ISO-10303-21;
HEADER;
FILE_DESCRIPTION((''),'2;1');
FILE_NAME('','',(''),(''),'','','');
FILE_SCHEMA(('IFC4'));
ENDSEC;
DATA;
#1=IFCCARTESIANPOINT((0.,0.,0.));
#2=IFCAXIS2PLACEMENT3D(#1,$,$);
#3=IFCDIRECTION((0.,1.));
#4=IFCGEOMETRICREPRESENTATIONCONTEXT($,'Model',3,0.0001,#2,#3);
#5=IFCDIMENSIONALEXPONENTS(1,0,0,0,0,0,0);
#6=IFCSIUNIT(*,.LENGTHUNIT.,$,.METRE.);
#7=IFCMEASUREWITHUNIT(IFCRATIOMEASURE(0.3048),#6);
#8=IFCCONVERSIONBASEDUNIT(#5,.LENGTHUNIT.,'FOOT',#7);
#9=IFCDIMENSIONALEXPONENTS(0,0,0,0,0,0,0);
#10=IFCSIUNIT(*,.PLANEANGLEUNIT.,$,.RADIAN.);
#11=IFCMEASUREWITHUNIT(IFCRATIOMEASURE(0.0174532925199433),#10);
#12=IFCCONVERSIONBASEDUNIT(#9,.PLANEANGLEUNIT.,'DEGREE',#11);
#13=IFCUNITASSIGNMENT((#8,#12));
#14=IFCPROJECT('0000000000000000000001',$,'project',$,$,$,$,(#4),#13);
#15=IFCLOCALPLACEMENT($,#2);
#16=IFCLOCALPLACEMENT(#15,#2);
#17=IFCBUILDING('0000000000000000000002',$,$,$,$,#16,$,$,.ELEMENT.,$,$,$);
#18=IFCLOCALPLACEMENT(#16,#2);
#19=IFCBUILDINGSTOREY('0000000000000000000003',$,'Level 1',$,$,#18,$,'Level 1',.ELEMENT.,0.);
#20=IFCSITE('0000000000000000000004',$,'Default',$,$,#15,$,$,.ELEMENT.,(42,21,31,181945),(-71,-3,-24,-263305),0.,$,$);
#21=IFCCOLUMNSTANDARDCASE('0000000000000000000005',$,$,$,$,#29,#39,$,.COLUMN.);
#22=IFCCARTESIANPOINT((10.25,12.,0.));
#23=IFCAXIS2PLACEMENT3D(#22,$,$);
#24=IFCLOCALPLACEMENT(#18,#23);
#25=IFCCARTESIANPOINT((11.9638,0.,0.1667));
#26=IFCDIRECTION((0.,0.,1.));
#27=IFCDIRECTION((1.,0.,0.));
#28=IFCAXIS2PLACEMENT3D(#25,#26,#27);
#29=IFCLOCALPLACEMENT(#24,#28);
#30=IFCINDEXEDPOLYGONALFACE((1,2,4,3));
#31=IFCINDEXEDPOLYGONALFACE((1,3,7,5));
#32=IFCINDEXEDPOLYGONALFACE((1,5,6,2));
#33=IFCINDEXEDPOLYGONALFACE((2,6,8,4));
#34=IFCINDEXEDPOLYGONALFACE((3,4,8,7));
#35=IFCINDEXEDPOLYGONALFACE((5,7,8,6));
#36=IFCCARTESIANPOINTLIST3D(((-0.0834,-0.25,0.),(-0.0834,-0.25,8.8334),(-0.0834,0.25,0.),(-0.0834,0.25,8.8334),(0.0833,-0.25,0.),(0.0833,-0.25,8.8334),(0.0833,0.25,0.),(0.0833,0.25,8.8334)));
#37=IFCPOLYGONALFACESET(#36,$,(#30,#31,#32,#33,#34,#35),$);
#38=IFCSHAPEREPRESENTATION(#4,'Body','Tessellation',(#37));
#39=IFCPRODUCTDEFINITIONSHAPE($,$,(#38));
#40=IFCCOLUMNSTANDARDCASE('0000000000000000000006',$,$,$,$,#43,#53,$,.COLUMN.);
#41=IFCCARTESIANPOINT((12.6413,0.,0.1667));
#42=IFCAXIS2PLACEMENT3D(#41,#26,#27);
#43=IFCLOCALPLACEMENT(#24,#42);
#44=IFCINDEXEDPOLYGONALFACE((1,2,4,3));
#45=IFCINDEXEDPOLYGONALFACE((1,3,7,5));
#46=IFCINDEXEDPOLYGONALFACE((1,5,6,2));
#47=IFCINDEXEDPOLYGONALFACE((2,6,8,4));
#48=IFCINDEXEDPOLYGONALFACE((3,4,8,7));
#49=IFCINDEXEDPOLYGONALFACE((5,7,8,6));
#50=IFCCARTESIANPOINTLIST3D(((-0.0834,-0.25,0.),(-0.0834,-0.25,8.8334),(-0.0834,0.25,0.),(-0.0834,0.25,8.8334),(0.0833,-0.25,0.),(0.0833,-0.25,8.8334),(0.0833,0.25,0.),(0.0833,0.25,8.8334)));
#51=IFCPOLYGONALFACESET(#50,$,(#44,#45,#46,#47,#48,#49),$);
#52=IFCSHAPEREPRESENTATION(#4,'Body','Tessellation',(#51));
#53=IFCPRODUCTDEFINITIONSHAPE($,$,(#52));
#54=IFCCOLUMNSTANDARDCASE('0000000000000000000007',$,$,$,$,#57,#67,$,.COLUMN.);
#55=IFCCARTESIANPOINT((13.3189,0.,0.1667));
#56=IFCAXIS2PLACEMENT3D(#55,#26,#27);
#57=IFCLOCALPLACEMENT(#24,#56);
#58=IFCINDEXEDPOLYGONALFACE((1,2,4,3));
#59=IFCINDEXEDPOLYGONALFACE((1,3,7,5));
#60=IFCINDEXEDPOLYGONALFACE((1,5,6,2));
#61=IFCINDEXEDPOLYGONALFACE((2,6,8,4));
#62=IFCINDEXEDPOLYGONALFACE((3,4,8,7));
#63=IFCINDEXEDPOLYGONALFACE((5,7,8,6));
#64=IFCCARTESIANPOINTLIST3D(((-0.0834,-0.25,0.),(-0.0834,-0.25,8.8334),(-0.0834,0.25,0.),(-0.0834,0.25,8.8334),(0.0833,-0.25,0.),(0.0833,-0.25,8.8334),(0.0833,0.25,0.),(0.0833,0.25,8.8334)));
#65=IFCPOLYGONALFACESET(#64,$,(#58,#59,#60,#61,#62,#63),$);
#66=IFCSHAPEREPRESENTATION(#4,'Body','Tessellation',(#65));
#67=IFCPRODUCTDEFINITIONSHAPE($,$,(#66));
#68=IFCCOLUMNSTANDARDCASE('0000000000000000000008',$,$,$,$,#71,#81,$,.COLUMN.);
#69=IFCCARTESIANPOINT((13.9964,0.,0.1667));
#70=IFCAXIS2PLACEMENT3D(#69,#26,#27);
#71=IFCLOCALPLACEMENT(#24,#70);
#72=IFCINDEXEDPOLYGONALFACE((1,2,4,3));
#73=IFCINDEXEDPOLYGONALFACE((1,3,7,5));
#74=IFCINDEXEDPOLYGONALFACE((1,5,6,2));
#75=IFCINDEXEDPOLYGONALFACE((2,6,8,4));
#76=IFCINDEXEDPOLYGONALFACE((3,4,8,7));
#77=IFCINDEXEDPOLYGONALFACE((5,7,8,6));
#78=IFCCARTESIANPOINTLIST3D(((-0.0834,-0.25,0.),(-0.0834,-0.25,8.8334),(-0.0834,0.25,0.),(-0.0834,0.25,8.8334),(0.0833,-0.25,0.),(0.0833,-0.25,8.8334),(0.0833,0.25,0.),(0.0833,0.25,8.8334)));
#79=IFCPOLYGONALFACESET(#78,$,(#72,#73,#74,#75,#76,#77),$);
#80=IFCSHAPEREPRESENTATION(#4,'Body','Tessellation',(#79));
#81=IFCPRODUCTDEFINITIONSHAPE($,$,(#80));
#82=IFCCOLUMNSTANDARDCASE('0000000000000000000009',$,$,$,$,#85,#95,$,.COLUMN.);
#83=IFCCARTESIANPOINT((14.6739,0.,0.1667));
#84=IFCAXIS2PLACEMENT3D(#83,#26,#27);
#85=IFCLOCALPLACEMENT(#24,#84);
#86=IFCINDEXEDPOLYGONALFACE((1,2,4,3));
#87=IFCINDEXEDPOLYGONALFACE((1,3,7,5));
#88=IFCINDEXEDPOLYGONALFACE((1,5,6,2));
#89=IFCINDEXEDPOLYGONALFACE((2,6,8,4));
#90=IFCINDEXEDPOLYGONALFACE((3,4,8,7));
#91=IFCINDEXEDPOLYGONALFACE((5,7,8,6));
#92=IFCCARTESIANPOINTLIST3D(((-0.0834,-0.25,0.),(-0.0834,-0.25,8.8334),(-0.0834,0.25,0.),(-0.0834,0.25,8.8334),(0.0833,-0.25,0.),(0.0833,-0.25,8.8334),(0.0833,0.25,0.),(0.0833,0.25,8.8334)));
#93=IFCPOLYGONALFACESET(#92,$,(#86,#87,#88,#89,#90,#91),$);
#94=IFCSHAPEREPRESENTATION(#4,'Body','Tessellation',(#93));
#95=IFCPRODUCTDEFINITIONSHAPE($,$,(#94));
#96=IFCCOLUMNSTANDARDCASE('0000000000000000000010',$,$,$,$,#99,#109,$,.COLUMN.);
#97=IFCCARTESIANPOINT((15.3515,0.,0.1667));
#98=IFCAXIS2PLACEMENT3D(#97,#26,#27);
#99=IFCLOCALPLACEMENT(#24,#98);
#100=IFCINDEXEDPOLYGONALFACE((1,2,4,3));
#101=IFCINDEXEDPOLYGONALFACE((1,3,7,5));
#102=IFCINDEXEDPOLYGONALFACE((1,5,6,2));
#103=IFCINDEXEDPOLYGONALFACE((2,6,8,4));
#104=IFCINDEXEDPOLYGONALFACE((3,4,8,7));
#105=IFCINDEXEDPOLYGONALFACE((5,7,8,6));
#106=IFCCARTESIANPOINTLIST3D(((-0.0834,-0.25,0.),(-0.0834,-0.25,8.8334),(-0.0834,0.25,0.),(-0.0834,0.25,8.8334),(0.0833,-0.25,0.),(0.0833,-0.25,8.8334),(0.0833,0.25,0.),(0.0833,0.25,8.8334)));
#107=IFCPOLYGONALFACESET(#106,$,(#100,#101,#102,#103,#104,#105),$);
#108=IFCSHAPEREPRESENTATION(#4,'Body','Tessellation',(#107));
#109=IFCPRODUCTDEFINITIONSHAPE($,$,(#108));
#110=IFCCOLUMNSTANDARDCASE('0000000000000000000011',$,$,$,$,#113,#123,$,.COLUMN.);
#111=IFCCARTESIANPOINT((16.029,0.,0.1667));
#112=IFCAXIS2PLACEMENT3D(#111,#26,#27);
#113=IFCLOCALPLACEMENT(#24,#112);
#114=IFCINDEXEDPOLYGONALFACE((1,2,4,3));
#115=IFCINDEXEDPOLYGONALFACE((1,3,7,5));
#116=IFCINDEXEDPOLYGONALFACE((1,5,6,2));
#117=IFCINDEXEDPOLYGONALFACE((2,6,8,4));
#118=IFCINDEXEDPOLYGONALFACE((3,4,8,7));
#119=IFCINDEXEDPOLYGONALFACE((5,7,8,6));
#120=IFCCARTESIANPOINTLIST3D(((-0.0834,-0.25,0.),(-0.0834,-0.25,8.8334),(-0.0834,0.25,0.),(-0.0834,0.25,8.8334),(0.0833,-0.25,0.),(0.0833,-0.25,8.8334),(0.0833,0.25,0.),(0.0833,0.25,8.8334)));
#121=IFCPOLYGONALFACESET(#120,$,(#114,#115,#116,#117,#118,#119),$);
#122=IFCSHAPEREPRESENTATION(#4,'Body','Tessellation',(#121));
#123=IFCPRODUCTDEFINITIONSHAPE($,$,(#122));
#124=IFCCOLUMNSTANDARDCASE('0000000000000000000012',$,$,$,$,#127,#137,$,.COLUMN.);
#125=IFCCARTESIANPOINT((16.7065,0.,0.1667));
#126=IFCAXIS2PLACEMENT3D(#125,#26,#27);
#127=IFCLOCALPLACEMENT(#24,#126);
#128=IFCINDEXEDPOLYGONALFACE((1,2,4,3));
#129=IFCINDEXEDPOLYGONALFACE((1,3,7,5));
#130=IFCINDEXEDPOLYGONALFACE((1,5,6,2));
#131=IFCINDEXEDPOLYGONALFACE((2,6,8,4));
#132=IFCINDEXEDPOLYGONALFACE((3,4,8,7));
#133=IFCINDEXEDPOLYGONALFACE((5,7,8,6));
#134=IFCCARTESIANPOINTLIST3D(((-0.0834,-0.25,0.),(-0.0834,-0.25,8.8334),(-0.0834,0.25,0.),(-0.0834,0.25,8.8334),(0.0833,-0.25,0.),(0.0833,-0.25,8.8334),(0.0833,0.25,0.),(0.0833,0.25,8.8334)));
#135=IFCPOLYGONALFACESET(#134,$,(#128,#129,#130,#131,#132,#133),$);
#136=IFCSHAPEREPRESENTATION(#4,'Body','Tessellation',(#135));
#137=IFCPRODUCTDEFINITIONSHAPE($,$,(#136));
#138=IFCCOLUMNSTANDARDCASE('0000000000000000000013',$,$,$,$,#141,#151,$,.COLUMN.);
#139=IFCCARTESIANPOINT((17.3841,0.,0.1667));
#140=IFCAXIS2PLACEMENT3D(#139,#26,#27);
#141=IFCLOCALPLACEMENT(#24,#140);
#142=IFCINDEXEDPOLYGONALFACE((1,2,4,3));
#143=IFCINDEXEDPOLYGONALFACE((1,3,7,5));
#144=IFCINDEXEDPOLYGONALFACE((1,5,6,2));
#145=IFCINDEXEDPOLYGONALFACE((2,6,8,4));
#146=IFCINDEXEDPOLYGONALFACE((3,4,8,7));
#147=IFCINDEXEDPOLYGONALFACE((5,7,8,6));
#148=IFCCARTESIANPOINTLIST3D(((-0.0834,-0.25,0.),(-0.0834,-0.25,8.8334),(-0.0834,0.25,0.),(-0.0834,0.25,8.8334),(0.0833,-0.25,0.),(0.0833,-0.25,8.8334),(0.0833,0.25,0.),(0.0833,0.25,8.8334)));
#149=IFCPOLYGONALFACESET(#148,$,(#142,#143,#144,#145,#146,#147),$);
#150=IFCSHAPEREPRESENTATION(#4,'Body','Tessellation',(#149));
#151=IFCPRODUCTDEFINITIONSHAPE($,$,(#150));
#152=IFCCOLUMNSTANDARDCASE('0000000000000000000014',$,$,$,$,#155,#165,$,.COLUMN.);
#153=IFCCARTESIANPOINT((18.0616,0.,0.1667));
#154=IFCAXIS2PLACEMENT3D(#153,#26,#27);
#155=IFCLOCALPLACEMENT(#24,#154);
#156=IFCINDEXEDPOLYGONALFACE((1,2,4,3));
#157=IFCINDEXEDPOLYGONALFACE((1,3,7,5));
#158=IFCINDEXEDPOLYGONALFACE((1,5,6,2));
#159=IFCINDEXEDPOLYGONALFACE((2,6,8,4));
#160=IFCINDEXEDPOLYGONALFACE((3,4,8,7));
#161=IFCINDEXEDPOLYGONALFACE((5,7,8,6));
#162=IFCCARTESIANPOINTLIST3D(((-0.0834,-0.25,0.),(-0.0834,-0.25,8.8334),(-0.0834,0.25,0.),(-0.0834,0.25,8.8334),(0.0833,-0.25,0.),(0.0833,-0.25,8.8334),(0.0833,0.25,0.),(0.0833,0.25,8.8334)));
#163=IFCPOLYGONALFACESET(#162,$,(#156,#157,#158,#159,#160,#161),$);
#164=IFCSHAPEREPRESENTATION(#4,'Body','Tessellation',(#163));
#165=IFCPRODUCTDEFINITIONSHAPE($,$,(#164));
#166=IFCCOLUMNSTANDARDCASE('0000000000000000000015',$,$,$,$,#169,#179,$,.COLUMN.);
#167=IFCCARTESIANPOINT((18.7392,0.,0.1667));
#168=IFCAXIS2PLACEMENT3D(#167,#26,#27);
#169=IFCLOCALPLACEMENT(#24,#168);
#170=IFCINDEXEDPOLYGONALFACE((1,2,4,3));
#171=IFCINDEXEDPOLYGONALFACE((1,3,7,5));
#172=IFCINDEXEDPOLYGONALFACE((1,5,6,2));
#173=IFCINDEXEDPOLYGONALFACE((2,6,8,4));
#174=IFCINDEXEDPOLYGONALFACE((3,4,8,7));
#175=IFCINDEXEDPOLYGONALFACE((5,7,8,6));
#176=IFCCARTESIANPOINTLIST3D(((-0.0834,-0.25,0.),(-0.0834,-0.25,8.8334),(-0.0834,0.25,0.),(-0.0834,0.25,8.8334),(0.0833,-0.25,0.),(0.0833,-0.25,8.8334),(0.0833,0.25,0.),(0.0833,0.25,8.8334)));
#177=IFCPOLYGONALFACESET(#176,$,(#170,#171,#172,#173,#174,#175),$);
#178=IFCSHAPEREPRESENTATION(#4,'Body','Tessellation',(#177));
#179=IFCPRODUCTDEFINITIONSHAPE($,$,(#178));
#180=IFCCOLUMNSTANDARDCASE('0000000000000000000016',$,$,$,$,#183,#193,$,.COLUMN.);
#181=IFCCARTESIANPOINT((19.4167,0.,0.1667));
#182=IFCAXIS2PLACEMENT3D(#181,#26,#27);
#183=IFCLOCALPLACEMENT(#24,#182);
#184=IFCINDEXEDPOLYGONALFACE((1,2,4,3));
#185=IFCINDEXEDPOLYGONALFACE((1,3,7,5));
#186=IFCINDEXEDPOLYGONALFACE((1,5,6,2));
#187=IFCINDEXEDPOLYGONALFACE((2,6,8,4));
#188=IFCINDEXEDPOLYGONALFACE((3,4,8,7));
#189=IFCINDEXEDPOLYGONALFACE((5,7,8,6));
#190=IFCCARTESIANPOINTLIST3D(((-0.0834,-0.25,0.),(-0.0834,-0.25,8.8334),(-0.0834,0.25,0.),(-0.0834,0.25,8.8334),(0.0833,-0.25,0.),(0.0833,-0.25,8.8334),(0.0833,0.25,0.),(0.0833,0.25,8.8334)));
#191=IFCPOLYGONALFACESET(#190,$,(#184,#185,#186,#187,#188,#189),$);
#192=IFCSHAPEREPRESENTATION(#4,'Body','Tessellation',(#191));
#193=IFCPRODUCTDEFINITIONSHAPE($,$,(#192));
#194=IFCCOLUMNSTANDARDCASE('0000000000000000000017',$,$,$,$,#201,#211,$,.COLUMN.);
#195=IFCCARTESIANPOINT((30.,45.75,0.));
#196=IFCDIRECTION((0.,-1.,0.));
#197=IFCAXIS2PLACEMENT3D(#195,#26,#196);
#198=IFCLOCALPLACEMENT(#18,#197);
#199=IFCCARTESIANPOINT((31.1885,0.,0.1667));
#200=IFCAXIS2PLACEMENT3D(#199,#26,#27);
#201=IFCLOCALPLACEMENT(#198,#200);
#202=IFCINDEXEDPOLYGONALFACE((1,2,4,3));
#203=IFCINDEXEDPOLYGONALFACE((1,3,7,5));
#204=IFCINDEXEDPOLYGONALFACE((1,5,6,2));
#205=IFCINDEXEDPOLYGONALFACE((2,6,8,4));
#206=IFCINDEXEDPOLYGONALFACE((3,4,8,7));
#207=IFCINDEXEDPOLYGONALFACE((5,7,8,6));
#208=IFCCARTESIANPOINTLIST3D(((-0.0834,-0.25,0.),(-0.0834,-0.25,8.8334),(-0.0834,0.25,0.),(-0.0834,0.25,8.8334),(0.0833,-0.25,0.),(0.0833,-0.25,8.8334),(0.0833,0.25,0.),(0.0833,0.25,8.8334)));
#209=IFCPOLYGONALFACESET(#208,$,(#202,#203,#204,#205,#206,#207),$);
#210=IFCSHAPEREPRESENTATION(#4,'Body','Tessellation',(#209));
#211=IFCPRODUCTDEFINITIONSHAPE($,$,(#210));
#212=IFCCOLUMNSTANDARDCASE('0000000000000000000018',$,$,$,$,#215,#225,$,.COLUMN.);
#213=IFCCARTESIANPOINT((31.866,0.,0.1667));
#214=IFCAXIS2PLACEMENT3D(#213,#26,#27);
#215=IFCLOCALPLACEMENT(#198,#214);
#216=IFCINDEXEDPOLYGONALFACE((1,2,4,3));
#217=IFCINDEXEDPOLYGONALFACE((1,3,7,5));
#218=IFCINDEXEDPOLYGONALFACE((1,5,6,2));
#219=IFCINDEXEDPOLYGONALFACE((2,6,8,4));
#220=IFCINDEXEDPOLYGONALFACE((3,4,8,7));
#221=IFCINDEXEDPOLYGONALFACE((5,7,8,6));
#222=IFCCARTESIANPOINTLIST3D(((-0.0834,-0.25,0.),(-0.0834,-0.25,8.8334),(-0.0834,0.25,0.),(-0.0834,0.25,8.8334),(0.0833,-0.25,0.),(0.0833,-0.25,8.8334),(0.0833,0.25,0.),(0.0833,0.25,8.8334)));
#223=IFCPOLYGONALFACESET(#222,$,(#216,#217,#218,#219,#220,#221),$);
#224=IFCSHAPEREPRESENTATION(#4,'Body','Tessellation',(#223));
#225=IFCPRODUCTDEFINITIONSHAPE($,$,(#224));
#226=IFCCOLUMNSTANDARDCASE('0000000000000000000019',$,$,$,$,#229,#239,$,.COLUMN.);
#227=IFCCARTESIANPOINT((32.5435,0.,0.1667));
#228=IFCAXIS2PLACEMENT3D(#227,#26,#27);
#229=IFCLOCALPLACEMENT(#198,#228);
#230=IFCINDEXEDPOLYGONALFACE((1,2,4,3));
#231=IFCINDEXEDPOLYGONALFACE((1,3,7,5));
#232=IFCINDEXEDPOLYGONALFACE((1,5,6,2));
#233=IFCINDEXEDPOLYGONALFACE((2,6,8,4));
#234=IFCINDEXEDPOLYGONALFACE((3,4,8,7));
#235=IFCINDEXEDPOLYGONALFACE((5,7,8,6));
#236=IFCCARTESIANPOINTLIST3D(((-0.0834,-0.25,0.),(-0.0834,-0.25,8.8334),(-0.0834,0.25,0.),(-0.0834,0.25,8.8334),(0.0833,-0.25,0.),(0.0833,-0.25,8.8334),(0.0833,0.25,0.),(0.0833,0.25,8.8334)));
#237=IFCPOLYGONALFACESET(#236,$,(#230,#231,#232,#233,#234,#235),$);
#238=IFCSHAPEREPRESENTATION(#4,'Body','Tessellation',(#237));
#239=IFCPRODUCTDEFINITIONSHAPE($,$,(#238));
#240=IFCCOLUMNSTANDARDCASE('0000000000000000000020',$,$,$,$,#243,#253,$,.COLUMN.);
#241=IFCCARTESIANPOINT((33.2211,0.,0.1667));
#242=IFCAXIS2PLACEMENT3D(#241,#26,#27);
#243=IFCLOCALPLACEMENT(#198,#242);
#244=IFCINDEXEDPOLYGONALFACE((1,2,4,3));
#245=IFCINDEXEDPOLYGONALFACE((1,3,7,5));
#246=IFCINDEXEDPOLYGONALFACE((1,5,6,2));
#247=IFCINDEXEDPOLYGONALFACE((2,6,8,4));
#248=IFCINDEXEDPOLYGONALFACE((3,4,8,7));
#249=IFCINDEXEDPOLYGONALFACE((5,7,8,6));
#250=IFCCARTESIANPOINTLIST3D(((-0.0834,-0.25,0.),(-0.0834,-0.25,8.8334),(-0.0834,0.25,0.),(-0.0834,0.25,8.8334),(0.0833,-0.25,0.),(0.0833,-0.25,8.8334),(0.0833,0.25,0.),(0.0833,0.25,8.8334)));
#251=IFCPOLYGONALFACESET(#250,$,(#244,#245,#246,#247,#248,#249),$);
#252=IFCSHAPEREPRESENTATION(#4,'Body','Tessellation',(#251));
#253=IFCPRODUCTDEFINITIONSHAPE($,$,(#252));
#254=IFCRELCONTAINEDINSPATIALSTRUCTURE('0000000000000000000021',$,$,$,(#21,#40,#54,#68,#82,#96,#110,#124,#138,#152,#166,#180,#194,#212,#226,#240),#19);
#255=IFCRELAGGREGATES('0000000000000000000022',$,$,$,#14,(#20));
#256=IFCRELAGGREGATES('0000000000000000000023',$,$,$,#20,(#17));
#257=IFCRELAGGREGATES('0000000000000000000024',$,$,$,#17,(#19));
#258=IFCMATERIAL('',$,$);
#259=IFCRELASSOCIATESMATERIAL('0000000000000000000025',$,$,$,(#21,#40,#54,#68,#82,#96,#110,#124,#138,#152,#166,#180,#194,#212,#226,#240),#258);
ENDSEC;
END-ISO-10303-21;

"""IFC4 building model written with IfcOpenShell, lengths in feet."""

from ifc_helpers import new_model, entity, si_unit, converted_unit, direction, frame, origin, place, context, project, spatial, rectangle, extrude, material, element, save


model = new_model("IFC4")

# Units and contexts
model_context = context("Model", 3, precision=0.0001, world=origin(), true_north=direction((0.0, 1.0)))
ifc_project = project(units=[converted_unit("LENGTHUNIT", "FOOT", entity("IfcRatioMeasure", 0.3048), si_unit("LENGTHUNIT", "METRE"), dimensions=[1, 0, 0, 0, 0, 0, 0]), converted_unit("PLANEANGLEUNIT", "DEGREE", entity("IfcRatioMeasure", 0.0174532925199433), si_unit("PLANEANGLEUNIT", "RADIAN"), dimensions=[0, 0, 0, 0, 0, 0, 0])], contexts=[model_context])

# Site, building, storey
site_placement = place(None, origin())
site = spatial("IfcSite", under=ifc_project, at=site_placement, Name="Default", CompositionType="ELEMENT", RefLatitude=(42, 21, 31, 181945), RefLongitude=(-71, -3, -24, -263305), RefElevation=0.0)
building_placement = place(site_placement, origin())
building = spatial("IfcBuilding", under=site, at=building_placement, CompositionType="ELEMENT")
storey_placement = place(building_placement, origin())
storey = spatial("IfcBuildingStorey", under=building, at=storey_placement, Name="Level 1", LongName="Level 1", CompositionType="ELEMENT", Elevation=0.0)

# Columns
ifc_material_1 = material(Name="")
placement_1 = place(storey_placement, frame((10.25, 12.0, 0.0)))
for number, where, z_axis, x_axis in (
    (1, (11.9638, 0.0, 0.1667), (0.0, 0.0, 1.0), (1.0, 0.0, 0.0)),
    (2, (12.6413, 0.0, 0.1667), (0.0, 0.0, 1.0), (1.0, 0.0, 0.0)),
    (3, (13.3189, 0.0, 0.1667), (0.0, 0.0, 1.0), (1.0, 0.0, 0.0)),
    (4, (13.9964, 0.0, 0.1667), (0.0, 0.0, 1.0), (1.0, 0.0, 0.0)),
    (5, (14.6739, 0.0, 0.1667), (0.0, 0.0, 1.0), (1.0, 0.0, 0.0)),
    (6, (15.3515, 0.0, 0.1667), (0.0, 0.0, 1.0), (1.0, 0.0, 0.0)),
    (7, (16.029, 0.0, 0.1667), (0.0, 0.0, 1.0), (1.0, 0.0, 0.0)),
    (8, (16.7065, 0.0, 0.1667), (0.0, 0.0, 1.0), (1.0, 0.0, 0.0)),
    (9, (17.3841, 0.0, 0.1667), (0.0, 0.0, 1.0), (1.0, 0.0, 0.0)),
    (10, (18.0616, 0.0, 0.1667), (0.0, 0.0, 1.0), (1.0, 0.0, 0.0)),
    (11, (18.7392, 0.0, 0.1667), (0.0, 0.0, 1.0), (1.0, 0.0, 0.0)),
    (12, (19.4167, 0.0, 0.1667), (0.0, 0.0, 1.0), (1.0, 0.0, 0.0)),
):
    element("IfcColumnStandardCase", number, at=place(placement_1, frame(where, z_axis=z_axis, x_axis=x_axis)), inside=storey, material=ifc_material_1, PredefinedType="COLUMN", context=model_context, shape_type="SweptSolid", body=[
        extrude(rectangle(XDim=0.1667, YDim=0.5), origin(), (0.0, 0.0, 1.0), 8.8334),
    ])
placement_2 = place(storey_placement, frame((30.0, 45.75, 0.0), z_axis=(0.0, 0.0, 1.0), x_axis=(0.0, -1.0, 0.0)))
for number, where, z_axis, x_axis in (
    (13, (31.1885, 0.0, 0.1667), (0.0, 0.0, 1.0), (1.0, 0.0, 0.0)),
    (14, (31.866, 0.0, 0.1667), (0.0, 0.0, 1.0), (1.0, 0.0, 0.0)),
    (15, (32.5435, 0.0, 0.1667), (0.0, 0.0, 1.0), (1.0, 0.0, 0.0)),
    (16, (33.2211, 0.0, 0.1667), (0.0, 0.0, 1.0), (1.0, 0.0, 0.0)),
):
    element("IfcColumnStandardCase", number, at=place(placement_2, frame(where, z_axis=z_axis, x_axis=x_axis)), inside=storey, material=ifc_material_1, PredefinedType="COLUMN", context=model_context, shape_type="SweptSolid", body=[
        extrude(rectangle(XDim=0.1667, YDim=0.5), origin(), (0.0, 0.0, 1.0), 8.8334),
    ])

save(model, "model.ifc")
